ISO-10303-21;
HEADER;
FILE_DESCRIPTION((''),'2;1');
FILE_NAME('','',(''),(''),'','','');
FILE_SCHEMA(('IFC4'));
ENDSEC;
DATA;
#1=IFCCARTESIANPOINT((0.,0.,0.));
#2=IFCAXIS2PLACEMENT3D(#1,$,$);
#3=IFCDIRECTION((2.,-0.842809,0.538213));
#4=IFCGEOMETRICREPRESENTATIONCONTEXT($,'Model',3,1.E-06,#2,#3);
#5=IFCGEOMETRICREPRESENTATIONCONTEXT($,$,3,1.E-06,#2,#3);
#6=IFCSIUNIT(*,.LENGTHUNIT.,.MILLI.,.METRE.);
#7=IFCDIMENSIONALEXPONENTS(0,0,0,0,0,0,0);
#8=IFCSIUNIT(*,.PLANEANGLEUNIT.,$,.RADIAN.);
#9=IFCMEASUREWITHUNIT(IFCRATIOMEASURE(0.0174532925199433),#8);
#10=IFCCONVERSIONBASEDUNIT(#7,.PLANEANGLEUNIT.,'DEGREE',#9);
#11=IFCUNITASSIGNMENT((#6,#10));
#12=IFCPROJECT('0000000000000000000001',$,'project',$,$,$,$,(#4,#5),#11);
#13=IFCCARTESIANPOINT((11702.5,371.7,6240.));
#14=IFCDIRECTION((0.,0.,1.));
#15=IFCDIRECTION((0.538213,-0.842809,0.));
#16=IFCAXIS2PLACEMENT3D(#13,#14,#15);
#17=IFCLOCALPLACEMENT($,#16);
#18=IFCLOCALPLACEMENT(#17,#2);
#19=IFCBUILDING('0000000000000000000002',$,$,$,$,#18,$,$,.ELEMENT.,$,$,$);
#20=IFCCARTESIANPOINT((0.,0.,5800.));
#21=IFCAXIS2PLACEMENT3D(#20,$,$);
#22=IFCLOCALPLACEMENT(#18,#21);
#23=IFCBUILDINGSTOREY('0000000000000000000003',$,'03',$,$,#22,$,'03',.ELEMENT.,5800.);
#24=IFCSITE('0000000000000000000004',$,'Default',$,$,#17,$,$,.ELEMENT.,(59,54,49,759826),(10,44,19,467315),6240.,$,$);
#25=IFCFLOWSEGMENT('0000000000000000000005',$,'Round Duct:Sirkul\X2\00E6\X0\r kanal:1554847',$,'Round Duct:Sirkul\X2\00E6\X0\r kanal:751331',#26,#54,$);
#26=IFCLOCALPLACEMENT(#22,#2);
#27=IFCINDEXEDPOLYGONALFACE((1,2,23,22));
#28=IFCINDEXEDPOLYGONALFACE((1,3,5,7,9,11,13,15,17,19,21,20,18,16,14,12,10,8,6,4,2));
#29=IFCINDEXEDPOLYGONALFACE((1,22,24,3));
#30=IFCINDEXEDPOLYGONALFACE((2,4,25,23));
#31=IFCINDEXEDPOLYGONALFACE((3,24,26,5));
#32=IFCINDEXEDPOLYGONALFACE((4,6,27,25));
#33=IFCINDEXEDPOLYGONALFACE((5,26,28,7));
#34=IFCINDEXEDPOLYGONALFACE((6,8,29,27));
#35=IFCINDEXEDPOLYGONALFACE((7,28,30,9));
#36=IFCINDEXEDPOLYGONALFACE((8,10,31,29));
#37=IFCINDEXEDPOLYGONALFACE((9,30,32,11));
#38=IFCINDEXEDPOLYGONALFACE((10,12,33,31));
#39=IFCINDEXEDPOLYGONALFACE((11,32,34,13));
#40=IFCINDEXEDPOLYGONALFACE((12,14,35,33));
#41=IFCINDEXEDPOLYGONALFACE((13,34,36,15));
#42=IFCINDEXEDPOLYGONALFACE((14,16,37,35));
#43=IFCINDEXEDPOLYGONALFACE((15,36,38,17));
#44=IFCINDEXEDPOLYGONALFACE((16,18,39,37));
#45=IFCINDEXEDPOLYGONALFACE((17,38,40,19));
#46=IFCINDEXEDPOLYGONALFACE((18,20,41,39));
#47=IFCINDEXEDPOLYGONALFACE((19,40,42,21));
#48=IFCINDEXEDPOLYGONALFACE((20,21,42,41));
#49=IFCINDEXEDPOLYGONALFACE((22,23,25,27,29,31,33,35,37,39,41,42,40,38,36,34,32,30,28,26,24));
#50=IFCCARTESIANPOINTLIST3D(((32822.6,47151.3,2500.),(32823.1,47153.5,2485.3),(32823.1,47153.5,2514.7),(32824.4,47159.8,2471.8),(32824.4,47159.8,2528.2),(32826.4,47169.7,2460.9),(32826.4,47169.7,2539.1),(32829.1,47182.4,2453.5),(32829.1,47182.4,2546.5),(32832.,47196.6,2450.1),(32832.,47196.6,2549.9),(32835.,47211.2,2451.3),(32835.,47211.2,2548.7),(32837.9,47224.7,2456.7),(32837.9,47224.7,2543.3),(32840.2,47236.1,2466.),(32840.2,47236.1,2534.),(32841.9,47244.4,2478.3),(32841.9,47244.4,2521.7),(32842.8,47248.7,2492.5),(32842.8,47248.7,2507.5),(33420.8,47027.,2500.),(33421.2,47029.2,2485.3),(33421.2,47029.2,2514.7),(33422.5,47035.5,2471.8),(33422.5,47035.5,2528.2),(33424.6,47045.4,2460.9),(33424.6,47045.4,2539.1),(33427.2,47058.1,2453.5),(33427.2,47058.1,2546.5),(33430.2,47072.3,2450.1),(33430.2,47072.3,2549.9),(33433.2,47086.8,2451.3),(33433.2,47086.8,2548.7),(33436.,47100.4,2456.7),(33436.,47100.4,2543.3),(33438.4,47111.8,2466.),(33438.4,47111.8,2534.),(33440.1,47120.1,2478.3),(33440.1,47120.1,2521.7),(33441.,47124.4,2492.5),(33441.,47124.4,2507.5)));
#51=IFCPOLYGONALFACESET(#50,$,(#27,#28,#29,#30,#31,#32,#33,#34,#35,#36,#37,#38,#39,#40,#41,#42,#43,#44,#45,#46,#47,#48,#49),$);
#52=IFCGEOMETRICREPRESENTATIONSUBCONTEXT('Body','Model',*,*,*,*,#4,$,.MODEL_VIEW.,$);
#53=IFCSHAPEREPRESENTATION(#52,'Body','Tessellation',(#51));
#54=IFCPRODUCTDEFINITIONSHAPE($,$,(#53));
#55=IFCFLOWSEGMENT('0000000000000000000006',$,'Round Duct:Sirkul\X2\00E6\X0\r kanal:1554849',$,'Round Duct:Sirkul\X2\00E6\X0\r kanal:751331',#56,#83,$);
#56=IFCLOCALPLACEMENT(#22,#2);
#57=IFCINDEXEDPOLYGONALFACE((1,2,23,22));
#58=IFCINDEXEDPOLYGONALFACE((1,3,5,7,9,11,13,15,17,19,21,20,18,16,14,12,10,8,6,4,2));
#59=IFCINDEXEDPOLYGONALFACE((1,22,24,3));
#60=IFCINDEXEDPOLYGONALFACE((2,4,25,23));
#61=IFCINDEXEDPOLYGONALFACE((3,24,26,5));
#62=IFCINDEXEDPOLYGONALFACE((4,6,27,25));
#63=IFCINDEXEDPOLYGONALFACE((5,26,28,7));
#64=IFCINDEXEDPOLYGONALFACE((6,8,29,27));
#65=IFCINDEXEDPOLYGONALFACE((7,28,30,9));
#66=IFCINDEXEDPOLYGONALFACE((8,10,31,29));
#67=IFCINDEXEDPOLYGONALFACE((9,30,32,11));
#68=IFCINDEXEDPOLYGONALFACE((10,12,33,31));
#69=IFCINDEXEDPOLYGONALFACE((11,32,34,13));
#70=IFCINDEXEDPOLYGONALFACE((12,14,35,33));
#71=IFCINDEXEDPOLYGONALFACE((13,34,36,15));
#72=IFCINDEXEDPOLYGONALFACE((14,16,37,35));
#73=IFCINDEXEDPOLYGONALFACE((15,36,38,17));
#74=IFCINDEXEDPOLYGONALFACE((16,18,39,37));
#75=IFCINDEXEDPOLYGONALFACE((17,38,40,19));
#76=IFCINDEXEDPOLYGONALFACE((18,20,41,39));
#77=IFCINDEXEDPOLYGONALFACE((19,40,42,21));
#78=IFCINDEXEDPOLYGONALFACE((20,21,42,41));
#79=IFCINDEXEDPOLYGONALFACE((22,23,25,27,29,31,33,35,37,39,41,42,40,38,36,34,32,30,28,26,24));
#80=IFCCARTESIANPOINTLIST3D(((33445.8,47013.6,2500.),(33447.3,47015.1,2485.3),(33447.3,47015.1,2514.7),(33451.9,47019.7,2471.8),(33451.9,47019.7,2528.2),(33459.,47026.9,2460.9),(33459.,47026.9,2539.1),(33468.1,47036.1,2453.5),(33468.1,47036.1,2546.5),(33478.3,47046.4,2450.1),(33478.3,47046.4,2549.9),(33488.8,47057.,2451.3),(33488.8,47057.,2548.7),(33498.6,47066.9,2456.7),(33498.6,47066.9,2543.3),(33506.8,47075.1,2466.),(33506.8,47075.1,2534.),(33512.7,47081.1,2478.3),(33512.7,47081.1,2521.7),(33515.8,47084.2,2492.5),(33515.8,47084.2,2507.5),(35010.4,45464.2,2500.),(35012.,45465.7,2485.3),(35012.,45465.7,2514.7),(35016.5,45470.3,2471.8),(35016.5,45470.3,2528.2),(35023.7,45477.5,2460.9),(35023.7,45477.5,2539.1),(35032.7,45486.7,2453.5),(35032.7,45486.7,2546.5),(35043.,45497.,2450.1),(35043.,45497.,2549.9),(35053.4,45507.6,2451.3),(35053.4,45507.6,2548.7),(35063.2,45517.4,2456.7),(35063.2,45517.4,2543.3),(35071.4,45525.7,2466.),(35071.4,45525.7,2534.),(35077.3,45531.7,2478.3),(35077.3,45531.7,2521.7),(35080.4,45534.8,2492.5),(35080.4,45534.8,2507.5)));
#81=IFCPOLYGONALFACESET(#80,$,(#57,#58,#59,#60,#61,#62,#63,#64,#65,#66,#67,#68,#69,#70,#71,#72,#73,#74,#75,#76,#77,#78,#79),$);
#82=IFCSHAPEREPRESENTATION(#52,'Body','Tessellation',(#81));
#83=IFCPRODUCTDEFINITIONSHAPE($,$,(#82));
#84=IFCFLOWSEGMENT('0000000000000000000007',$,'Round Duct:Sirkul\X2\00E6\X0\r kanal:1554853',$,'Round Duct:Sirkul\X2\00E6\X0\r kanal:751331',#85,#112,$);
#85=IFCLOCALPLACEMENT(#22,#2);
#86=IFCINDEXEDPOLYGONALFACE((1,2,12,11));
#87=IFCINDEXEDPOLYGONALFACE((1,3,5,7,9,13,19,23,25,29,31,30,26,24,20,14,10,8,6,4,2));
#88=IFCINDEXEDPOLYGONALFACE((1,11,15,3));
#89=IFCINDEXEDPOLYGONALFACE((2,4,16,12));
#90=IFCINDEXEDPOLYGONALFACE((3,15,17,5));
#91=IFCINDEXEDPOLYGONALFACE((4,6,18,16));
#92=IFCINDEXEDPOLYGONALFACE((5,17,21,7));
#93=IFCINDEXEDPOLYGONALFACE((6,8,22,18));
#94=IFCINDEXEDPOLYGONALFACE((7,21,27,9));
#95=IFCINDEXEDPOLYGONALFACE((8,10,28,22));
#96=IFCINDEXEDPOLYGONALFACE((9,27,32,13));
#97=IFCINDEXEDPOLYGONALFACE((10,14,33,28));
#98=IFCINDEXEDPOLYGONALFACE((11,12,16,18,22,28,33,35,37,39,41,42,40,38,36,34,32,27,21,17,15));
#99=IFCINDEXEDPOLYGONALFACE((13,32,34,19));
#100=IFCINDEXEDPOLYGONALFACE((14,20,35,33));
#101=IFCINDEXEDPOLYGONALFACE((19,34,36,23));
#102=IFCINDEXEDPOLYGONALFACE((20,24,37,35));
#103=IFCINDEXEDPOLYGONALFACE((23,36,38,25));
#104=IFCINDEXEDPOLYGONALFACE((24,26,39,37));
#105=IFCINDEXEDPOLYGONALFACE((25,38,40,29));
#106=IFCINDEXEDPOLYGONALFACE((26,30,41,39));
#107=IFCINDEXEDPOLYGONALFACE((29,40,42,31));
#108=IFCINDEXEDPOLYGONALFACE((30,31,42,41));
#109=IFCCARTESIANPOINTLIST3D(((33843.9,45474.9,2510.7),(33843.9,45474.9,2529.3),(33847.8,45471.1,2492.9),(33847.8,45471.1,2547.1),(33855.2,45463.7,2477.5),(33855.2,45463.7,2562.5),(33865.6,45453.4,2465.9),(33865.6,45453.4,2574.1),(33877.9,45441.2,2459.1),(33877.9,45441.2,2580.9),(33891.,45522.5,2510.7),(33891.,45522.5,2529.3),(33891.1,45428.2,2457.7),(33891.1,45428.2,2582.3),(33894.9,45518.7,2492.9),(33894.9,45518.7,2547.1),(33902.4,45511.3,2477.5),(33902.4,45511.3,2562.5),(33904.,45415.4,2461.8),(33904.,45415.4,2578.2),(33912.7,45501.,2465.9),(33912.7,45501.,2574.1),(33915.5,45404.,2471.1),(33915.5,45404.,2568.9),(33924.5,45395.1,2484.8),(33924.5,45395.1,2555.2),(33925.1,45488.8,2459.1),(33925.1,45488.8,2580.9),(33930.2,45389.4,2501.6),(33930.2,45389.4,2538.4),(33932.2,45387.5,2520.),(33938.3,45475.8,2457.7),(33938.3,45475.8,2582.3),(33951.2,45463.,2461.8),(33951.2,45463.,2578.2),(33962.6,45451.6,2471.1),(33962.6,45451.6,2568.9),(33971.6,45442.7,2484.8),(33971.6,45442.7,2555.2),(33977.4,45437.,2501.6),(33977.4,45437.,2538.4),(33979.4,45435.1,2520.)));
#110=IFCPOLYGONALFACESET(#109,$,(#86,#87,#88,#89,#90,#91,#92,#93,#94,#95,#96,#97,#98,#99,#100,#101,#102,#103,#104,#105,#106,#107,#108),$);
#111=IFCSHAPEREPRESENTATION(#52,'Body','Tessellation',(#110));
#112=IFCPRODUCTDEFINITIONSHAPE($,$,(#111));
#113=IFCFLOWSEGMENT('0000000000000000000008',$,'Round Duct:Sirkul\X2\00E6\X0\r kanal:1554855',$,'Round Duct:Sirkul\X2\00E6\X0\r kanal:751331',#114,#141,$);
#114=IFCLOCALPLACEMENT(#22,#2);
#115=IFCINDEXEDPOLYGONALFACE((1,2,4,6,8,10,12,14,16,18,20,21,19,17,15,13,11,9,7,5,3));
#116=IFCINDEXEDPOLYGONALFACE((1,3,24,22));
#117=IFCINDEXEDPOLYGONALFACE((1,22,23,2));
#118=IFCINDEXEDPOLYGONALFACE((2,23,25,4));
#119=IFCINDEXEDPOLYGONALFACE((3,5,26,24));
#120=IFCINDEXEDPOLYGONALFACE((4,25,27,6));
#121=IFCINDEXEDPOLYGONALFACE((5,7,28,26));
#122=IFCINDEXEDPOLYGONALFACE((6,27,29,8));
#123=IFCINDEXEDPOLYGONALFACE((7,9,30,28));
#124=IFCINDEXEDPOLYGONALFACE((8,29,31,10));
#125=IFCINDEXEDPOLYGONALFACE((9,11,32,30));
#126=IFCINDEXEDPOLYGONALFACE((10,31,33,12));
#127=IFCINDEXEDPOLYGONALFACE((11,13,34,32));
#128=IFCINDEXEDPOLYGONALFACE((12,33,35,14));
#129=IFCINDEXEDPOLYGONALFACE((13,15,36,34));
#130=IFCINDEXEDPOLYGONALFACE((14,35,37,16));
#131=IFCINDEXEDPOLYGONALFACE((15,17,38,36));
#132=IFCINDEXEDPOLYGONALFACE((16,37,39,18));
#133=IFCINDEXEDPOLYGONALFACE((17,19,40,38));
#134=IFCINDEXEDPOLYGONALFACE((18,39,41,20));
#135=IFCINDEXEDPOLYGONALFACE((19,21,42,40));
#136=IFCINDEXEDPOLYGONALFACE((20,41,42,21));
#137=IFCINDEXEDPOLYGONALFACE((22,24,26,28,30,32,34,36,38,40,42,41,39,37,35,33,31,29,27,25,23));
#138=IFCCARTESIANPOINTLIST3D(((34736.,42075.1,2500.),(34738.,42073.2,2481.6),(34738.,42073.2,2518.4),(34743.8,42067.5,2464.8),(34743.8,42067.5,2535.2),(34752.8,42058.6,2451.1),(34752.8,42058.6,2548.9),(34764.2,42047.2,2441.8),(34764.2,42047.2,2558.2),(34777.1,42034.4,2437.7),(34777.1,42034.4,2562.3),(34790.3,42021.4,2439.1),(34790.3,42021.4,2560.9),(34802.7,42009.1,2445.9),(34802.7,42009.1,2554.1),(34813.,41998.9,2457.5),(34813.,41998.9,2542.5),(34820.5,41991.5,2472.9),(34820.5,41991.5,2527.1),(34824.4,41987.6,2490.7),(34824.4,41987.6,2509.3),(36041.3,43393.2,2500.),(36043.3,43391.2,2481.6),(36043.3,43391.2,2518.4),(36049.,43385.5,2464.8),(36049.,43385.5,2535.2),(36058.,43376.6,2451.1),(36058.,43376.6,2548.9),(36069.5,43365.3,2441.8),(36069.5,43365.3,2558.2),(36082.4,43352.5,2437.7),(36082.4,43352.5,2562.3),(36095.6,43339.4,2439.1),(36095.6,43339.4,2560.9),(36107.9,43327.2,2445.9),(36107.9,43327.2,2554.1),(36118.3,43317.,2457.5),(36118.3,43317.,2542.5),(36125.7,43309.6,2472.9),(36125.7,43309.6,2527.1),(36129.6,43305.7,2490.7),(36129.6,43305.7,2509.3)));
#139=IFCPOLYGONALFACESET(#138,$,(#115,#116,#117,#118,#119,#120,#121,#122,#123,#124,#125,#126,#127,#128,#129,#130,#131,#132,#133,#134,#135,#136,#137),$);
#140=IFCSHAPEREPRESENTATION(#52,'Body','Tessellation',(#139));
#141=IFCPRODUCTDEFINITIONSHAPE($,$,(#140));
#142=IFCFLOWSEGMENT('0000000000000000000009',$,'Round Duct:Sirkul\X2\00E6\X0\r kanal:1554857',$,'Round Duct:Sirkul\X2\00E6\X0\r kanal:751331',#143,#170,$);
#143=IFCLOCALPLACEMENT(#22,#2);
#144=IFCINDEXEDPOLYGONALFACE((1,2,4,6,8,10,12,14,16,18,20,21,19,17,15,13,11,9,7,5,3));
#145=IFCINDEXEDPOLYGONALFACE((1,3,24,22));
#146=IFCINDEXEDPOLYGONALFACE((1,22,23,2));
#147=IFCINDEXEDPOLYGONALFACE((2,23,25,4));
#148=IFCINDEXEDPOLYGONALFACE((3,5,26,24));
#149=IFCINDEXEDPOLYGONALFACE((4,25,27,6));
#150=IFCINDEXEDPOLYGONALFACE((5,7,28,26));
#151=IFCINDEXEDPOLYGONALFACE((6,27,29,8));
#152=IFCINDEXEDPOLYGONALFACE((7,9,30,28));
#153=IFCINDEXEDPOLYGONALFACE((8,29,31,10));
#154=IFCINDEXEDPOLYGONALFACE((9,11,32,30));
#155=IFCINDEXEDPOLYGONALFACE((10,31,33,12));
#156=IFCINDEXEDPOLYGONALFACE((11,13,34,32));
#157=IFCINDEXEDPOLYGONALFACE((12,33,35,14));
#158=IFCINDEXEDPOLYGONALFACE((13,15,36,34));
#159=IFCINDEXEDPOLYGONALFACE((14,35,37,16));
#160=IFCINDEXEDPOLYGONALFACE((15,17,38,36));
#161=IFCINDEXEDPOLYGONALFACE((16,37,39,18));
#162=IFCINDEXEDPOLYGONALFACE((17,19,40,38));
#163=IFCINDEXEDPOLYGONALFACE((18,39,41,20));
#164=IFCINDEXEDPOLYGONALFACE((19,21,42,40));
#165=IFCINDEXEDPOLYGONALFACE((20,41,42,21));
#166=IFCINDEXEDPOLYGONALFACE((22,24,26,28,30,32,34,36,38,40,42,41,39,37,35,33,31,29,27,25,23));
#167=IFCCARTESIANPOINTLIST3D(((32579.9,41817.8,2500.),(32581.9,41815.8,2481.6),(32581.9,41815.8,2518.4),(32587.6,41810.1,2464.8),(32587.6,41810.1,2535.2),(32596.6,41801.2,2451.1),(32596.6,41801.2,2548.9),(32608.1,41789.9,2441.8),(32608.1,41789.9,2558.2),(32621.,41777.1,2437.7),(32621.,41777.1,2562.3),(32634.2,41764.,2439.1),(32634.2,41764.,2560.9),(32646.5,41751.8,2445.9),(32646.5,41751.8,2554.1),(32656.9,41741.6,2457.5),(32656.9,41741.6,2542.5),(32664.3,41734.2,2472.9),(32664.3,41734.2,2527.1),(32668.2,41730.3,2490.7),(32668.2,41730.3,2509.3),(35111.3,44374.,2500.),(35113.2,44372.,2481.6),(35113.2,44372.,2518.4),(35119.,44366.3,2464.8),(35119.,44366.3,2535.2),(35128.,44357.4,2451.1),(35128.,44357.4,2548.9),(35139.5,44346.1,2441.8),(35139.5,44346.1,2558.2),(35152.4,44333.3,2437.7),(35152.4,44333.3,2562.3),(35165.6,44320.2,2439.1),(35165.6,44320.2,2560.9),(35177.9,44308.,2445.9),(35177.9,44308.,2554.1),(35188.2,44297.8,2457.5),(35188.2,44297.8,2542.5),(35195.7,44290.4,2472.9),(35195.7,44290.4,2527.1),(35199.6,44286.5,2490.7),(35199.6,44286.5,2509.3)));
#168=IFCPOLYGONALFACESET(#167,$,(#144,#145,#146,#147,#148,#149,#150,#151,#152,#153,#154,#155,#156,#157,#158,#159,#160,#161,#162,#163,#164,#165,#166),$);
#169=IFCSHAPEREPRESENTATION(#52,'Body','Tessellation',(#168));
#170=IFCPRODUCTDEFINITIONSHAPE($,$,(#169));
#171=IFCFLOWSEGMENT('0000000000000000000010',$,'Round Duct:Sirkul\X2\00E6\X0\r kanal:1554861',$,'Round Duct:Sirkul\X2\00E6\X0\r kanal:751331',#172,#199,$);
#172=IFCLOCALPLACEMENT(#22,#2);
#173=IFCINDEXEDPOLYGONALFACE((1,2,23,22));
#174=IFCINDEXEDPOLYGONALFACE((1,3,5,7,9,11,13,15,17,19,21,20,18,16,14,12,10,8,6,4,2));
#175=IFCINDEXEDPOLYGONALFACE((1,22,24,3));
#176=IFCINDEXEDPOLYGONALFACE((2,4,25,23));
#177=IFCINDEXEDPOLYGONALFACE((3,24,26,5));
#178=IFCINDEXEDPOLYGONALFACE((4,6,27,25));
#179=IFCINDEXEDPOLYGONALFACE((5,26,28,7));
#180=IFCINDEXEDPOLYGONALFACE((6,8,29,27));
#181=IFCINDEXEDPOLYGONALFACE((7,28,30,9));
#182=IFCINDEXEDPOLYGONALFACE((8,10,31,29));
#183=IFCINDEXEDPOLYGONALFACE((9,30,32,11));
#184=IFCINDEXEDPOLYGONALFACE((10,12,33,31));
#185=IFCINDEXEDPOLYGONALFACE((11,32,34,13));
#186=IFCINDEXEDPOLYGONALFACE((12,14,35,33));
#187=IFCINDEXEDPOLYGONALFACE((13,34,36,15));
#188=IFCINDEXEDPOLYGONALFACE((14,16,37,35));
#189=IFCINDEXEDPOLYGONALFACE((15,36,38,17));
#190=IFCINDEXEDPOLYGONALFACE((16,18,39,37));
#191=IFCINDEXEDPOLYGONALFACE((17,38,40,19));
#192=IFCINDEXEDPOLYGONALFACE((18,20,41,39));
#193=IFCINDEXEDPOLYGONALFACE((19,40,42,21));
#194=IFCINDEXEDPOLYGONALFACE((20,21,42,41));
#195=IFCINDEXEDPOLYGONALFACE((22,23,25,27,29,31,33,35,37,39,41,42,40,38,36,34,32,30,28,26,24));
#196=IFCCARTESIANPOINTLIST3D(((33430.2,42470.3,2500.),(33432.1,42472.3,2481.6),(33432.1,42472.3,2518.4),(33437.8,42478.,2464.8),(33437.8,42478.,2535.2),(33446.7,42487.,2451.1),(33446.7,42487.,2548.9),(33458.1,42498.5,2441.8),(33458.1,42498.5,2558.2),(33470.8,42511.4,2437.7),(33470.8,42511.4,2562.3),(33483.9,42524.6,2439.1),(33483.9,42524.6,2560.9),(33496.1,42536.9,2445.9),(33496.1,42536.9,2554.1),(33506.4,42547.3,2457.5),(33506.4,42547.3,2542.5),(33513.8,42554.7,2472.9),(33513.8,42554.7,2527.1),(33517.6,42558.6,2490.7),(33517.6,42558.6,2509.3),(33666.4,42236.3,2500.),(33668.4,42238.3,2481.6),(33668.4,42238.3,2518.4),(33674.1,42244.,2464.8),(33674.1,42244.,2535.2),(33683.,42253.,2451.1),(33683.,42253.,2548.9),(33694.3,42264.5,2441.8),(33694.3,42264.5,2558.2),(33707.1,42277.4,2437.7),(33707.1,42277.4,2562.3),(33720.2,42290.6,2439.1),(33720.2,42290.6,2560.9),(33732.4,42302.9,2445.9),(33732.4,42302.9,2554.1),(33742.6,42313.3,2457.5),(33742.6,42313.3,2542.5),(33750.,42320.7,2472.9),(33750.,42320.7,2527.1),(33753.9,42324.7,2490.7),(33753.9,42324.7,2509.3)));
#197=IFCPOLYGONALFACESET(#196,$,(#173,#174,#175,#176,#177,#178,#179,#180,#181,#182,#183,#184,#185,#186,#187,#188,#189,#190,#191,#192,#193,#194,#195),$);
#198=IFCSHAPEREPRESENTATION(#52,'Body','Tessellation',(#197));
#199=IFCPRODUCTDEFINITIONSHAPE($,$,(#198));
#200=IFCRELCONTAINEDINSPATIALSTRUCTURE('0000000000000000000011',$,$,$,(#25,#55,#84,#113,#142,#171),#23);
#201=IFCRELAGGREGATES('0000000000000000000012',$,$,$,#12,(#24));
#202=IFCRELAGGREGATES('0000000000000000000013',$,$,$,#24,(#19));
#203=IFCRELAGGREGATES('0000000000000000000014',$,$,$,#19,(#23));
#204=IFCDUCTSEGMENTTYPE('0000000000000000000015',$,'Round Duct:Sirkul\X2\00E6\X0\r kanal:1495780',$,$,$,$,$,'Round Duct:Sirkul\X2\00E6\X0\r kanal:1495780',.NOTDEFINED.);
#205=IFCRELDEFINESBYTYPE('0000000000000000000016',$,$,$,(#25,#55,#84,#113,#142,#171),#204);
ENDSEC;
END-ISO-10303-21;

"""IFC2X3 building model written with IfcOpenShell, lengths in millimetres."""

from ifc_helpers import new_model, entity, si_unit, converted_unit, direction, frame, frame_2d, origin, origin_2d_with_axis, place, context, subcontext, project, spatial, circle, extrude, type_object, element, save


model = new_model("IFC2X3")

# Units and contexts
model_context = context("Model", 3, precision=1e-06, world=origin(), true_north=direction((2.0, -0.842809, 0.538213)))
context_of_model = context(None, 3, precision=1e-06, world=origin(), true_north=direction((2.0, -0.842809, 0.538213)))
body_context = subcontext(model_context, "Body", "Model", "MODEL_VIEW")
ifc_project = project(units=[si_unit("LENGTHUNIT", "METRE", prefix="MILLI"), converted_unit("PLANEANGLEUNIT", "DEGREE", entity("IfcRatioMeasure", 0.0174532925199433), si_unit("PLANEANGLEUNIT", "RADIAN"), dimensions=[0, 0, 0, 0, 0, 0, 0])], contexts=[model_context, context_of_model])

# Site, building, storey
site_placement = place(None, frame((11702.5, 371.7, 6240.0), z_axis=(0.0, 0.0, 1.0), x_axis=(0.538213, -0.842809, 0.0)))
site = spatial("IfcSite", under=ifc_project, at=site_placement, Name="Default", CompositionType="ELEMENT", RefLatitude=(59, 54, 49, 759826), RefLongitude=(10, 44, 19, 467315), RefElevation=6240.0)
building_placement = place(site_placement, origin())
building = spatial("IfcBuilding", under=site, at=building_placement, CompositionType="ELEMENT")
storey_placement = place(building_placement, frame((0.0, 0.0, 5800.0)))
storey = spatial("IfcBuildingStorey", under=building, at=storey_placement, Name="03", LongName="03", CompositionType="ELEMENT", Elevation=5800.0)

# Flow segments
duct_segment_type_1 = type_object("IfcDuctSegmentType", Name="Round Duct:Sirkulær kanal:1495780", ElementType="Round Duct:Sirkulær kanal:1495780", PredefinedType="NOTDEFINED")
flow_segment_1_placement = place(storey_placement, origin())
element("IfcFlowSegment", 1, at=flow_segment_1_placement, inside=storey, type_object=duct_segment_type_1, Name="Round Duct:Sirkulær kanal:1554847", ObjectType="Round Duct:Sirkulær kanal:751331", context=body_context, shape_type="SweptSolid", body=[
    extrude(circle(Radius=50.0, at=frame_2d((0.0, 0.0), x_axis=(1.0, 0.0))), frame((32832.8, 47200.3, 2500.0), z_axis=(0.979081, -0.203471, 0.0), x_axis=(-0.203471, -0.979081, 0.0)), (0.0, 0.0, 1.0), 610.9),
])
flow_segment_2_placement = place(storey_placement, origin())
element("IfcFlowSegment", 2, at=flow_segment_2_placement, inside=storey, type_object=duct_segment_type_1, Name="Round Duct:Sirkulær kanal:1554849", ObjectType="Round Duct:Sirkulær kanal:751331", context=body_context, shape_type="SweptSolid", body=[
    extrude(circle(Radius=50.0, at=origin_2d_with_axis()), frame((35045.6, 45499.7, 2500.0), z_axis=(-0.710554, 0.703643, 0.0), x_axis=(-0.703643, -0.710554, 0.0)), (0.0, 0.0, 1.0), 2202.0),
])
flow_segment_3_placement = place(storey_placement, origin())
element("IfcFlowSegment", 3, at=flow_segment_3_placement, inside=storey, type_object=duct_segment_type_1, Name="Round Duct:Sirkulær kanal:1554853", ObjectType="Round Duct:Sirkulær kanal:751331", context=body_context, shape_type="SweptSolid", body=[
    extrude(circle(Radius=62.5, at=origin_2d_with_axis()), frame((33887.8, 45431.4, 2520.0), z_axis=(0.703643, 0.710554, 0.0), x_axis=(0.710554, -0.703643, 0.0)), (0.0, 0.0, 1.0), 67.0),
])
flow_segment_4_placement = place(storey_placement, origin())
element("IfcFlowSegment", 4, at=flow_segment_4_placement, inside=storey, type_object=duct_segment_type_1, Name="Round Duct:Sirkulær kanal:1554855", ObjectType="Round Duct:Sirkulær kanal:751331", context=body_context, shape_type="SweptSolid", body=[
    extrude(circle(Radius=62.5, at=frame_2d((0.0, 0.0), x_axis=(1.0, 0.0))), frame((34780.4, 42031.1, 2500.0), z_axis=(0.703643, 0.710554, 0.0), x_axis=(-0.710554, 0.703643, 0.0)), (0.0, 0.0, 1.0), 1855.0),
])
flow_segment_5_placement = place(storey_placement, origin())
element("IfcFlowSegment", 5, at=flow_segment_5_placement, inside=storey, type_object=duct_segment_type_1, Name="Round Duct:Sirkulær kanal:1554857", ObjectType="Round Duct:Sirkulær kanal:751331", context=body_context, shape_type="SweptSolid", body=[
    extrude(circle(Radius=62.5, at=origin_2d_with_axis()), frame((32624.3, 41773.8, 2500.0), z_axis=(0.703643, 0.710554, 0.0), x_axis=(-0.710554, 0.703643, 0.0)), (0.0, 0.0, 1.0), 3597.5),
])
flow_segment_6_placement = place(storey_placement, origin())
element("IfcFlowSegment", 6, at=flow_segment_6_placement, inside=storey, type_object=duct_segment_type_1, Name="Round Duct:Sirkulær kanal:1554861", ObjectType="Round Duct:Sirkulær kanal:751331", context=body_context, shape_type="SweptSolid", body=[
    extrude(circle(Radius=62.5, at=frame_2d((0.0, 0.0), x_axis=(1.0, 0.0))), frame((33710.4, 42280.7, 2500.0), z_axis=(-0.710554, 0.703643, 0.0), x_axis=(-0.703643, -0.710554, 0.0)), (0.0, 0.0, 1.0), 332.5),
])

save(model, "model.ifc")
